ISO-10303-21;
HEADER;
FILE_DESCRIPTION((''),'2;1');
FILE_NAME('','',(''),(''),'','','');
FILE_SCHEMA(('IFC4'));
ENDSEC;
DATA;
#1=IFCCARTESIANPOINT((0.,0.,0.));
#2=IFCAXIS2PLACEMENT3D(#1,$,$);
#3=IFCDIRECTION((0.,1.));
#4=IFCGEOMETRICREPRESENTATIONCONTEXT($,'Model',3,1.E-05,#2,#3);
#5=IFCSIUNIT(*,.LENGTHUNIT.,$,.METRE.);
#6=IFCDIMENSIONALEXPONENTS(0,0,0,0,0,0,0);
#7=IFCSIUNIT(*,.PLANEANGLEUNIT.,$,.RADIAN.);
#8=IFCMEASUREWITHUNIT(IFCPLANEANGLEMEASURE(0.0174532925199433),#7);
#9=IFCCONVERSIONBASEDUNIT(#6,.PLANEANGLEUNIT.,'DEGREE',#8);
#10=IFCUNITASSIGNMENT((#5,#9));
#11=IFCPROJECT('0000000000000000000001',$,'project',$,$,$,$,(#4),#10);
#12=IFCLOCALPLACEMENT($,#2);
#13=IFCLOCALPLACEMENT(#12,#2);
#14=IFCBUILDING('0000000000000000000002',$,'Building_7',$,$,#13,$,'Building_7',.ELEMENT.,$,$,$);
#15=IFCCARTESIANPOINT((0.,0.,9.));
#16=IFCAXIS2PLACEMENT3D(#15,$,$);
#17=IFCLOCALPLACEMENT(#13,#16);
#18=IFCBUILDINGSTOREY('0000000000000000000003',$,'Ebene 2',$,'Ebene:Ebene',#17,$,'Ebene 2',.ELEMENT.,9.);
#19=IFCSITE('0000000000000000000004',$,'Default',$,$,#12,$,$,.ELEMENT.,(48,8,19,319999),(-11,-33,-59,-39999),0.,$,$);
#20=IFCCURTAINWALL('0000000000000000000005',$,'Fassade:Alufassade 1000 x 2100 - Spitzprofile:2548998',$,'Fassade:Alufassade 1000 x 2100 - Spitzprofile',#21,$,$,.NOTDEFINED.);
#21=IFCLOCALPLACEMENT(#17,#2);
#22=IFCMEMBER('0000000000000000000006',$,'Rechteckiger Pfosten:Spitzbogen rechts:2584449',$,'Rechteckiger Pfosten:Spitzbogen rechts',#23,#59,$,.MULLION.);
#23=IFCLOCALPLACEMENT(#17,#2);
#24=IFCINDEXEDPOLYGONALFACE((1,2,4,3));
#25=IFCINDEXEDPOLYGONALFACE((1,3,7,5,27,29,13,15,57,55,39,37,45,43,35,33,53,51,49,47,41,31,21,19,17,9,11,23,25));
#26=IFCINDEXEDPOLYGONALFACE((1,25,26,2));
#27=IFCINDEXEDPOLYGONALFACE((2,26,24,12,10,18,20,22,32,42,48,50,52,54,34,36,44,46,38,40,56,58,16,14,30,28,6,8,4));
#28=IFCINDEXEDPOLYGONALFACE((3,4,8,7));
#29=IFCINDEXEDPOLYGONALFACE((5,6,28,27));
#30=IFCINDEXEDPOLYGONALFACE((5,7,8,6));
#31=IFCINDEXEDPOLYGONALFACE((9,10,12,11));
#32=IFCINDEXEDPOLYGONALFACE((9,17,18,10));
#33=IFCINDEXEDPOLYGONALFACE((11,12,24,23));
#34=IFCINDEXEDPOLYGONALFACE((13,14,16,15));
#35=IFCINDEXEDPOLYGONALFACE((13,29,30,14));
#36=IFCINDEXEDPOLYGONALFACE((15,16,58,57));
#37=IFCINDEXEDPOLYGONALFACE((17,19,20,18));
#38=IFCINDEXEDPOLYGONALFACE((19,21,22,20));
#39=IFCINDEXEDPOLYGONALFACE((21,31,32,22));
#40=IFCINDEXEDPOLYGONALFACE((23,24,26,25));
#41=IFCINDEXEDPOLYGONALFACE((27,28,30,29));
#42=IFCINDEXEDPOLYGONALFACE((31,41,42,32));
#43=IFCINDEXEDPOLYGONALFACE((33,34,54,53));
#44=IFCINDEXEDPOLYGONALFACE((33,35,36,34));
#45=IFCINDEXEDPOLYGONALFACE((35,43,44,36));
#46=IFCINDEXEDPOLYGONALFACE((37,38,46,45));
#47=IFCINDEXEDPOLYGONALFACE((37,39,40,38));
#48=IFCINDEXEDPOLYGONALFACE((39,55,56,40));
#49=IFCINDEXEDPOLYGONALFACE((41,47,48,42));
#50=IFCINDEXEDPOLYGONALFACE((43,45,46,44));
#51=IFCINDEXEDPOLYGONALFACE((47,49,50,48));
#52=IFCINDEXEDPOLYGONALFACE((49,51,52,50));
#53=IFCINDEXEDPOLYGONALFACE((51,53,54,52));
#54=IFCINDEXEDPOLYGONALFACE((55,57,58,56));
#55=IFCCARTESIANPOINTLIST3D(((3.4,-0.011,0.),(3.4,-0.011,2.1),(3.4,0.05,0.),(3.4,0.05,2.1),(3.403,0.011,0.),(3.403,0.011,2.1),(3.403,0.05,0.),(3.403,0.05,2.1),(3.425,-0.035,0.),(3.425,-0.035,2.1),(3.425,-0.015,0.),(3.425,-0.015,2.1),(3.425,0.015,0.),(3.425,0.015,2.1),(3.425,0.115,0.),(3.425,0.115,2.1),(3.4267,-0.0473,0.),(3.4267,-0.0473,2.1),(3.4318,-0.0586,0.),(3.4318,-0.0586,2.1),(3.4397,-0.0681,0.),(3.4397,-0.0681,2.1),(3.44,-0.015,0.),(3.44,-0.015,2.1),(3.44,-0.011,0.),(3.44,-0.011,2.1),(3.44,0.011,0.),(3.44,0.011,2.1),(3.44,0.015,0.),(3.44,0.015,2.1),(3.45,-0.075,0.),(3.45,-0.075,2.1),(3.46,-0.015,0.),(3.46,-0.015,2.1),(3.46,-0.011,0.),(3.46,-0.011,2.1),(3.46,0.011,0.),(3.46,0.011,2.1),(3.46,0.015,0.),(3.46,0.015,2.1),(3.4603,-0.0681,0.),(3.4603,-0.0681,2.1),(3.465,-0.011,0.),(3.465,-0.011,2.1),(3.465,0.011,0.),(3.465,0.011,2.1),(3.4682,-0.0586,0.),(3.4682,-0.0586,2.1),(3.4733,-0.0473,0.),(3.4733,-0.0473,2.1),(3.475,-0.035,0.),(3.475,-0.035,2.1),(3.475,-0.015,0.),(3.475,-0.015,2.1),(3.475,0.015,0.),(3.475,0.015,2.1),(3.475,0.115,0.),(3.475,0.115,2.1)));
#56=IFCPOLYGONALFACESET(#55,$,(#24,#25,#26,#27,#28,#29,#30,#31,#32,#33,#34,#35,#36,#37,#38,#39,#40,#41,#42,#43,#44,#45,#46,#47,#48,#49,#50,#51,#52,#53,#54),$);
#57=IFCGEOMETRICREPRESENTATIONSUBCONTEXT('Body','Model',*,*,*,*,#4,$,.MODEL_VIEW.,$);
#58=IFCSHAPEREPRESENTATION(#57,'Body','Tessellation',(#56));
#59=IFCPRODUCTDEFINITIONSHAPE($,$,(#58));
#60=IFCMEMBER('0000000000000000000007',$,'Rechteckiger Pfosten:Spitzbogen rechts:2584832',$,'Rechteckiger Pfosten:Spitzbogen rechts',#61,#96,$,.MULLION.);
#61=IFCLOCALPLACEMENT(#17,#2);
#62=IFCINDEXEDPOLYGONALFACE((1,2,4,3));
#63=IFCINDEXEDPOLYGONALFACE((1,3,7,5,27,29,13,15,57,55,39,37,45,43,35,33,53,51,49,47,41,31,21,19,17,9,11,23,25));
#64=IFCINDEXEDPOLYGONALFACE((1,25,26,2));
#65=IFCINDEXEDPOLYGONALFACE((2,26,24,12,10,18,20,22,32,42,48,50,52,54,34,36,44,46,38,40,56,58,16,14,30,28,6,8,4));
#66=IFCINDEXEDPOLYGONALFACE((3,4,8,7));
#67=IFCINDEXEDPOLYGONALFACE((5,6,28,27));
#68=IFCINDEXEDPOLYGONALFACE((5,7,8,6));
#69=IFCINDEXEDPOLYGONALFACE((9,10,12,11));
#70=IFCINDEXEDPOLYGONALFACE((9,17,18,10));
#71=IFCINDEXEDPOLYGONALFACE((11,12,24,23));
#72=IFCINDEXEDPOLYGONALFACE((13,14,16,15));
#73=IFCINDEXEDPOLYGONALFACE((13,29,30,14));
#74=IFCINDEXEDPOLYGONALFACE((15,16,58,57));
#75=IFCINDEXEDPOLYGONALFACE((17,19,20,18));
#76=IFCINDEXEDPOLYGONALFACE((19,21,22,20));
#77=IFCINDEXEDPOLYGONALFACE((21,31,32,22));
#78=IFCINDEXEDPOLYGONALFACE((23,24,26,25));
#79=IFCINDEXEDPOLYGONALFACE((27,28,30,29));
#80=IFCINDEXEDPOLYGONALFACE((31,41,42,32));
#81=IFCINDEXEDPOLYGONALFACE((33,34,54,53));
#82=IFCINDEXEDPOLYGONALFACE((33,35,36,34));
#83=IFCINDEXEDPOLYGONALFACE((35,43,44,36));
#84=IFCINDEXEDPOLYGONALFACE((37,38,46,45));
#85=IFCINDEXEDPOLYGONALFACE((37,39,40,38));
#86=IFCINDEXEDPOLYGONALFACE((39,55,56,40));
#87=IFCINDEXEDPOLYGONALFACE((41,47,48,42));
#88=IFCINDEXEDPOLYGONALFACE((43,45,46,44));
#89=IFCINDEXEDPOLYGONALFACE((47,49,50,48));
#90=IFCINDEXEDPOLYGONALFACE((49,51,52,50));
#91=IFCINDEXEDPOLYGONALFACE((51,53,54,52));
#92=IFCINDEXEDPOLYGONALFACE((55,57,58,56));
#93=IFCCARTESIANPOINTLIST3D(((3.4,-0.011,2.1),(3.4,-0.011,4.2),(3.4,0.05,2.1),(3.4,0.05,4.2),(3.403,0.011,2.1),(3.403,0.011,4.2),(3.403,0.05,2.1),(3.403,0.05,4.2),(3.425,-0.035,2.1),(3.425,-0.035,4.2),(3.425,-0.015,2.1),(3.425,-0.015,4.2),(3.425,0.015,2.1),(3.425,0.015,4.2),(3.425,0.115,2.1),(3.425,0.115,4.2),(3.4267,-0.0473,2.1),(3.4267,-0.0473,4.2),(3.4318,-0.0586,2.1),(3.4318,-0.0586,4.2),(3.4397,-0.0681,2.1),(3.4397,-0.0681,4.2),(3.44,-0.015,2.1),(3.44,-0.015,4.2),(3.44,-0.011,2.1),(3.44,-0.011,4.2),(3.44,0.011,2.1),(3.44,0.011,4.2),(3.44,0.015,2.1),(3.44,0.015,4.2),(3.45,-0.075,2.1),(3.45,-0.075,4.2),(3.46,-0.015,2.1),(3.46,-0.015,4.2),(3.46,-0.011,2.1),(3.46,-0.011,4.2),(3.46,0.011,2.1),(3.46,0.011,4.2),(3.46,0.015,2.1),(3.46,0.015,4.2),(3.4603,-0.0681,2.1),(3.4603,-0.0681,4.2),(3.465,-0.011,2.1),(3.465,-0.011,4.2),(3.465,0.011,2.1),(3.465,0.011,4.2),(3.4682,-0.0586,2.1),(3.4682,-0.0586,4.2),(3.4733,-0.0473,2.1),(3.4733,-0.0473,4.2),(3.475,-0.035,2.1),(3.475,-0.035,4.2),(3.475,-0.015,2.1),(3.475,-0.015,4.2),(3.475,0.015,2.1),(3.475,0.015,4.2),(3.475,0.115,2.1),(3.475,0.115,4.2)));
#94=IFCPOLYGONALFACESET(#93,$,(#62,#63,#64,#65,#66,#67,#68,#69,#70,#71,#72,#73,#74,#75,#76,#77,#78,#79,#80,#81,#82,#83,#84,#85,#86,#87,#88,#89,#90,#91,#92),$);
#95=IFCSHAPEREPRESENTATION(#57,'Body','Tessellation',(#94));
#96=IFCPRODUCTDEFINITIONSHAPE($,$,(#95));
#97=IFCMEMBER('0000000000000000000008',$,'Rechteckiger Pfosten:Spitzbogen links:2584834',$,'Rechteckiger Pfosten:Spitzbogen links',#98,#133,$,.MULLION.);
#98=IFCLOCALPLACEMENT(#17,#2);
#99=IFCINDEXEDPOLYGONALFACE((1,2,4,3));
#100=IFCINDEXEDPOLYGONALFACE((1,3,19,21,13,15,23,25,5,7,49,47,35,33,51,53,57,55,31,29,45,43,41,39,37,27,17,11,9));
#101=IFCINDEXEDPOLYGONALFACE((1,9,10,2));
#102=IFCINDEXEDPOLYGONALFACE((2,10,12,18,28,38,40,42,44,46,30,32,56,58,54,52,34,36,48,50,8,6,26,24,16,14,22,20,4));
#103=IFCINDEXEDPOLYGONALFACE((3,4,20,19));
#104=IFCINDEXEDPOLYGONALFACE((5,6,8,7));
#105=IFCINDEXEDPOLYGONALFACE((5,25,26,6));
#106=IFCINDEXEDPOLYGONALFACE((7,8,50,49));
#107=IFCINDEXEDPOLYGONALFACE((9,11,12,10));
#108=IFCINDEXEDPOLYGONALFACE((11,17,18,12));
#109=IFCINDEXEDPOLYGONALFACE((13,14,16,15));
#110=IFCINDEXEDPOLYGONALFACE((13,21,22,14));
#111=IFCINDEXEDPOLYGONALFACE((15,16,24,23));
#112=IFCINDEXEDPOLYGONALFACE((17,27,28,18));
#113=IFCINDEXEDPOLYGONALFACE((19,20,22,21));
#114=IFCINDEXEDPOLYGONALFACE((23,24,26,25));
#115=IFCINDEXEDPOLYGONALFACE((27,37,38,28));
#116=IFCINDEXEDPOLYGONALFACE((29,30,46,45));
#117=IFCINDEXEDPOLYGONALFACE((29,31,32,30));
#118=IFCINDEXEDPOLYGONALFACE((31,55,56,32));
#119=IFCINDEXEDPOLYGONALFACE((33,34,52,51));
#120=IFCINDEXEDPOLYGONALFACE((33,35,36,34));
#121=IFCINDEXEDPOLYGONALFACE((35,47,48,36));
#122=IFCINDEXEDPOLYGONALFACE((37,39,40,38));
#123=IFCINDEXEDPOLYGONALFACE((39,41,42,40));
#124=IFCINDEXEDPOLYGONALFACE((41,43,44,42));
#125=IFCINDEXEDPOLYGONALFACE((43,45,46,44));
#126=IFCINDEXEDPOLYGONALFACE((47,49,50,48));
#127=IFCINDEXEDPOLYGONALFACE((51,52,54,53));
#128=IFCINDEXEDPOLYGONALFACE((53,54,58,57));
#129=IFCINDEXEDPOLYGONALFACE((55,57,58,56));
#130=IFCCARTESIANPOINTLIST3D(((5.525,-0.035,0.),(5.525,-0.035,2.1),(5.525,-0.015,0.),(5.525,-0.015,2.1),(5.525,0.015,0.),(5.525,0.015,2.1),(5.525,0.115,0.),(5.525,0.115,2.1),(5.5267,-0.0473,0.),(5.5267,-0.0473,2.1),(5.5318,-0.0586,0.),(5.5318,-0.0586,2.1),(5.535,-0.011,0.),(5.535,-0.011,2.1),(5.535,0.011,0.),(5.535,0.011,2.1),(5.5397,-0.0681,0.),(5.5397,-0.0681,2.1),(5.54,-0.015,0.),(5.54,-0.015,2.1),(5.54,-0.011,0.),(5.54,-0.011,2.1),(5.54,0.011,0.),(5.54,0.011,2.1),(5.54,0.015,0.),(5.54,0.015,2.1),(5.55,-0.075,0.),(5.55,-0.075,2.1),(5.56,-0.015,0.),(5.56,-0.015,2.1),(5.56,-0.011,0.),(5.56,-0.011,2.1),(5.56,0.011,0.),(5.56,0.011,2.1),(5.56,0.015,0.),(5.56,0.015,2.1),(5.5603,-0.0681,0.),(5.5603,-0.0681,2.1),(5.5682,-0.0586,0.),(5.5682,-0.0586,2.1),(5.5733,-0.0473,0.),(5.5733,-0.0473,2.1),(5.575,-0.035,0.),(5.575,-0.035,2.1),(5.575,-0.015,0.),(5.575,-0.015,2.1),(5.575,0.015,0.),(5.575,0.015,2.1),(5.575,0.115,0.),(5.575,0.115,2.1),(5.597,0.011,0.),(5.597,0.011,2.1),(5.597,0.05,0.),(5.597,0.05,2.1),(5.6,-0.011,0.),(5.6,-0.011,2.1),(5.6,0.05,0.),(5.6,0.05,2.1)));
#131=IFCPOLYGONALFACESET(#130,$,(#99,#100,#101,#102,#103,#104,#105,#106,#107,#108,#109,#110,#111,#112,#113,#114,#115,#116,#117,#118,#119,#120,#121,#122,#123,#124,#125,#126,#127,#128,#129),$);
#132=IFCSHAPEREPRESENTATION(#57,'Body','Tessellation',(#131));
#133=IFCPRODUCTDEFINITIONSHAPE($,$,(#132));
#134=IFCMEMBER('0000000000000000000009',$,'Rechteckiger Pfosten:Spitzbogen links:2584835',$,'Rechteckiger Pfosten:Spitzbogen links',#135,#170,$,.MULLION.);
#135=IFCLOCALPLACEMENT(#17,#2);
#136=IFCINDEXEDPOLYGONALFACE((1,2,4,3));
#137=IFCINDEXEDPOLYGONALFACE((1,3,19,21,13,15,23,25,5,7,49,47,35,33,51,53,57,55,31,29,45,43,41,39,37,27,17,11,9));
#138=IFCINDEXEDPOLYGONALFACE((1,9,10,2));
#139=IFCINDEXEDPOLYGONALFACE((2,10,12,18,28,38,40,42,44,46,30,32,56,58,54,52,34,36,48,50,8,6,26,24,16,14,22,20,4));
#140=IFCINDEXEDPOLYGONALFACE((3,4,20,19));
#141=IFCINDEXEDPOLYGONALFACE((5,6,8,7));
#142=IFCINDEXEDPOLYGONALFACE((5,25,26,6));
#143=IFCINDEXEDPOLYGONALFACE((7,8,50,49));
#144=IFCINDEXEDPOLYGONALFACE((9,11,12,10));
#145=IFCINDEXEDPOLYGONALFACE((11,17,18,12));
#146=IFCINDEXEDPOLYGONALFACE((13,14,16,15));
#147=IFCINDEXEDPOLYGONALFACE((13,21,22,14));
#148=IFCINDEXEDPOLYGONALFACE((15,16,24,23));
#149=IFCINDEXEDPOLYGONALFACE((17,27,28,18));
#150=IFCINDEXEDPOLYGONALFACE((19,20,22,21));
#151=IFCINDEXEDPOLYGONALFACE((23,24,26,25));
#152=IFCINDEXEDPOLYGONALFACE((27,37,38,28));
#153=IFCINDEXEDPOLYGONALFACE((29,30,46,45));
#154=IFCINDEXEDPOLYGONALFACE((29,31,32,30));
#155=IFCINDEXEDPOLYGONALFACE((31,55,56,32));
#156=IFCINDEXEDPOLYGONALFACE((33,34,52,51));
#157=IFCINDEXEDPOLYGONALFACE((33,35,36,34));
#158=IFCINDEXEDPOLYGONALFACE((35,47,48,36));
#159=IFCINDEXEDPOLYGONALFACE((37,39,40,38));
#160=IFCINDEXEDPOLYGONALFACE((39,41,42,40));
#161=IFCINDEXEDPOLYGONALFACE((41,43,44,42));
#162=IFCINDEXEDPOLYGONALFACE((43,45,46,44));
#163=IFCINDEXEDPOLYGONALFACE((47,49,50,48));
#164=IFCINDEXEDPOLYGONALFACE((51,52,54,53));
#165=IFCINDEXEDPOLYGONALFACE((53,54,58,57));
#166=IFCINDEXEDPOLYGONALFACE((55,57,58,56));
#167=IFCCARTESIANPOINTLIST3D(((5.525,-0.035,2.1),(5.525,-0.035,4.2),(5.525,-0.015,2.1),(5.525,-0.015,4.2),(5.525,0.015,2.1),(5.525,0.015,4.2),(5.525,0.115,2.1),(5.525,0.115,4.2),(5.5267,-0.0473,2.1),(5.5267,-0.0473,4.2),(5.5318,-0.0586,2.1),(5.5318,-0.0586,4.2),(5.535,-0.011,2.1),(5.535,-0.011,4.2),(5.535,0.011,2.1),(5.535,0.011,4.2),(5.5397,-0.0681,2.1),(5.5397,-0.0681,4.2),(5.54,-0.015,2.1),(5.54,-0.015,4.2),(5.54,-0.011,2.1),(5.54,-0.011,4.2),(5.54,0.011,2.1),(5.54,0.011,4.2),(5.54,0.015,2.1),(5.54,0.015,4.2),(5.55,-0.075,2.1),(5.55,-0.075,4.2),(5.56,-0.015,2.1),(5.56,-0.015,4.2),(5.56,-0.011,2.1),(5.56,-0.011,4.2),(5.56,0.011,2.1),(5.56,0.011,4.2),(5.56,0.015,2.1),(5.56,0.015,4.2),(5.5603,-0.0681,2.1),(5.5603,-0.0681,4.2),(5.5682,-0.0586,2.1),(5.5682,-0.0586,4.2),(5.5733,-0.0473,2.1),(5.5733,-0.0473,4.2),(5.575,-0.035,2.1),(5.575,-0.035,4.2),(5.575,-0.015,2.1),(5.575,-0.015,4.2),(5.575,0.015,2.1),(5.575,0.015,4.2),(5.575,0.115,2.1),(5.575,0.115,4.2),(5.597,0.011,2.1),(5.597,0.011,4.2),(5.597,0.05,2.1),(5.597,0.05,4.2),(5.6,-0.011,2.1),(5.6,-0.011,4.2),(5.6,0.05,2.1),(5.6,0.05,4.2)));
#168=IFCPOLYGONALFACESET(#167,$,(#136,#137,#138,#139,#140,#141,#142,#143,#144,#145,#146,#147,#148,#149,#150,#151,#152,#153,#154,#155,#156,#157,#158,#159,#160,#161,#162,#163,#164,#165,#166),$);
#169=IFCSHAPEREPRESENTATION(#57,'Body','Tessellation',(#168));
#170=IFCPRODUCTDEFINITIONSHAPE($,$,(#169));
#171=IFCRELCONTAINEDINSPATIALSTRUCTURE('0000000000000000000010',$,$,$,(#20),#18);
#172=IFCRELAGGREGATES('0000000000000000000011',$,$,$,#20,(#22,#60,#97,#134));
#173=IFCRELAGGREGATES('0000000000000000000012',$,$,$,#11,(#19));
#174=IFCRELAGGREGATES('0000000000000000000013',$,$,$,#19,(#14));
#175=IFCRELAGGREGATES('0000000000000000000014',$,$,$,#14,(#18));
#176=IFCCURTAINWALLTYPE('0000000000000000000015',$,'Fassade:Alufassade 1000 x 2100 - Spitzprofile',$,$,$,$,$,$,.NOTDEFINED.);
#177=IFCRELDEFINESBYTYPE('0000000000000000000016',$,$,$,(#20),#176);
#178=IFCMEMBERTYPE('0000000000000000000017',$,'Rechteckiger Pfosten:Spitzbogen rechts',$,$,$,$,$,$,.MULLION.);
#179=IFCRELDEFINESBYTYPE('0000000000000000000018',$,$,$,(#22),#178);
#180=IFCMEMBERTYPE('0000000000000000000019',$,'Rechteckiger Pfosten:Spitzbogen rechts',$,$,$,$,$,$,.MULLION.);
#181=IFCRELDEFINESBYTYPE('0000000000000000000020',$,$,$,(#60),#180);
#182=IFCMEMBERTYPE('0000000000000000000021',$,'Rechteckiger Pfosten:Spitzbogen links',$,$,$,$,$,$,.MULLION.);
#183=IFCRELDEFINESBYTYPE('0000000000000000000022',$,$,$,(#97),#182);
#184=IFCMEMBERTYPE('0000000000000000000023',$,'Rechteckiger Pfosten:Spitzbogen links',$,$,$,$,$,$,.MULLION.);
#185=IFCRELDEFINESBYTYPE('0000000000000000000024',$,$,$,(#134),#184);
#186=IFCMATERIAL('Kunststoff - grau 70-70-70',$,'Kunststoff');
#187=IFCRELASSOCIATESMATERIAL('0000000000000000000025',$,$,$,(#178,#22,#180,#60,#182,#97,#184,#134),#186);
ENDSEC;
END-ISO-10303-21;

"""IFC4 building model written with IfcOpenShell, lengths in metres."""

from ifc_helpers import new_model, entity, si_unit, converted_unit, direction, frame, origin, place, context, subcontext, project, spatial, line, arc, indexed_curve, outline, extrude, source, transform, mapped, material, type_object, type_shapes, element, aggregate, save


model = new_model("IFC4")

# Units and contexts
model_context = context("Model", 3, precision=1e-05, world=origin(), true_north=direction((0.0, 1.0)))
body_context = subcontext(model_context, "Body", "Model", "MODEL_VIEW")
ifc_project = project(units=[si_unit("LENGTHUNIT", "METRE"), converted_unit("PLANEANGLEUNIT", "DEGREE", entity("IfcPlaneAngleMeasure", 0.0174532925199433), si_unit("PLANEANGLEUNIT", "RADIAN"), dimensions=[0, 0, 0, 0, 0, 0, 0])], contexts=[model_context])

# Site, building, storey
site_placement = place(None, origin())
site = spatial("IfcSite", under=ifc_project, at=site_placement, Name="Default", CompositionType="ELEMENT", RefLatitude=(48, 8, 19, 319999), RefLongitude=(-11, -33, -59, -39999), RefElevation=0.0)
building_placement = place(site_placement, origin())
building = spatial("IfcBuilding", under=site, at=building_placement, Name="Building_7", LongName="Building_7", CompositionType="ELEMENT")
storey_placement = place(building_placement, frame((0.0, 0.0, 9.0)))
storey = spatial("IfcBuildingStorey", under=building, at=storey_placement, Name="Ebene 2", ObjectType="Ebene:Ebene", LongName="Ebene 2", CompositionType="ELEMENT", Elevation=9.0)

# Curtain wall, members
curtain_wall_type = type_object("IfcCurtainWallType", Name="Fassade:Alufassade 1000 x 2100 - Spitzprofile", PredefinedType="NOTDEFINED")
curtain_wall_placement = place(storey_placement, frame((0.0, 0.0, -9.0)))
curtain_wall = element("IfcCurtainWall", 1, at=curtain_wall_placement, inside=storey, type_object=curtain_wall_type, Name="Fassade:Alufassade 1000 x 2100 - Spitzprofile:2548998", ObjectType="Fassade:Alufassade 1000 x 2100 - Spitzprofile", PredefinedType="NOTDEFINED")
ifc_material_1 = material(Name="Kunststoff - grau 70-70-70", Category="Kunststoff")
member_type_1 = type_object("IfcMemberType", Name="Rechteckiger Pfosten:Spitzbogen rechts", PredefinedType="MULLION", material=ifc_material_1)
shared_shape_1 = source(origin(), body_context, "Body", "SweptSolid", [
    extrude(outline(indexed_curve([(-0.107, -0.0321), (-0.007, -0.0321), (-0.007, -0.0171), (-0.003, -0.0171), (-0.003, -0.0221), (0.019, -0.0221), (0.019, -0.0171), (0.023, -0.0171), (0.023, -0.0321), (0.043, -0.0321), (0.0666, -0.0254), (0.083, -0.0071), (0.0666, 0.0111), (0.043, 0.0179), (0.023, 0.0179), (0.023, 0.0029), (0.019, 0.0029), (0.019, 0.0429), (-0.042, 0.0429), (-0.042, 0.0399), (-0.003, 0.0399), (-0.003, 0.0029), (-0.007, 0.0029), (-0.007, 0.0179), (-0.107, 0.0179)], segments=[line(1, 2, 3, 4, 5, 6, 7, 8, 9, 10), arc(10, 11, 12), arc(12, 13, 14), line(14, 15, 16, 17, 18, 19, 20, 21, 22, 23, 24, 25, 1)], self_intersect=False)), frame((-0.0429, 0.008, -2.1), z_axis=(0.0, 0.0, 1.0), x_axis=(0.0, -1.0, 0.0)), (0.0, 0.0, 1.0), 2.1),
])
type_shapes(member_type_1, [shared_shape_1])
member_1_placement = place(curtain_wall_placement, frame((3.4, 0.0, 9.0), z_axis=(0.0, 0.0, -1.0), x_axis=(-1.0, 0.0, 0.0)))
member_1 = element("IfcMember", 2, at=member_1_placement, type_object=member_type_1, material=ifc_material_1, Name="Rechteckiger Pfosten:Spitzbogen rechts:2584449", ObjectType="Rechteckiger Pfosten:Spitzbogen rechts", PredefinedType="MULLION", context=body_context, shape_type="MappedRepresentation", body=[
    mapped(shared_shape_1, transform((0.0, 0.0, 0.0), scale=1.0)),
])
member_type_2 = type_object("IfcMemberType", Name="Rechteckiger Pfosten:Spitzbogen rechts", PredefinedType="MULLION", material=ifc_material_1)
shared_shape_2 = source(origin(), body_context, "Body", "SweptSolid", [
    extrude(outline(indexed_curve([(-0.107, -0.0321), (-0.007, -0.0321), (-0.007, -0.0171), (-0.003, -0.0171), (-0.003, -0.0221), (0.019, -0.0221), (0.019, -0.0171), (0.023, -0.0171), (0.023, -0.0321), (0.043, -0.0321), (0.0666, -0.0254), (0.083, -0.0071), (0.0666, 0.0111), (0.043, 0.0179), (0.023, 0.0179), (0.023, 0.0029), (0.019, 0.0029), (0.019, 0.0429), (-0.042, 0.0429), (-0.042, 0.0399), (-0.003, 0.0399), (-0.003, 0.0029), (-0.007, 0.0029), (-0.007, 0.0179), (-0.107, 0.0179)], segments=[line(1, 2, 3, 4, 5, 6, 7, 8, 9, 10), arc(10, 11, 12), arc(12, 13, 14), line(14, 15, 16, 17, 18, 19, 20, 21, 22, 23, 24, 25, 1)], self_intersect=False)), frame((-0.0429, 0.008, -2.1), z_axis=(0.0, 0.0, 1.0), x_axis=(0.0, -1.0, 0.0)), (0.0, 0.0, 1.0), 2.1),
])
type_shapes(member_type_2, [shared_shape_2])
member_2_placement = place(curtain_wall_placement, frame((3.4, 0.0, 11.1), z_axis=(0.0, 0.0, -1.0), x_axis=(-1.0, 0.0, 0.0)))
member_2 = element("IfcMember", 3, at=member_2_placement, type_object=member_type_2, material=ifc_material_1, Name="Rechteckiger Pfosten:Spitzbogen rechts:2584832", ObjectType="Rechteckiger Pfosten:Spitzbogen rechts", PredefinedType="MULLION", context=body_context, shape_type="MappedRepresentation", body=[
    mapped(shared_shape_2, transform((0.0, 0.0, 0.0), scale=1.0)),
])
member_type_3 = type_object("IfcMemberType", Name="Rechteckiger Pfosten:Spitzbogen links", PredefinedType="MULLION", material=ifc_material_1)
shared_shape_3 = source(origin(), body_context, "Body", "SweptSolid", [
    extrude(outline(indexed_curve([(-0.107, -0.0321), (-0.007, -0.0321), (-0.007, -0.0171), (-0.003, -0.0171), (-0.003, -0.0221), (0.019, -0.0221), (0.019, -0.0171), (0.023, -0.0171), (0.023, -0.0321), (0.043, -0.0321), (0.0666, -0.0254), (0.083, -0.0071), (0.0666, 0.0111), (0.043, 0.0179), (0.023, 0.0179), (0.023, 0.0029), (0.019, 0.0029), (0.019, 0.0429), (-0.042, 0.0429), (-0.042, 0.0399), (-0.003, 0.0399), (-0.003, 0.0029), (-0.007, 0.0029), (-0.007, 0.0179), (-0.107, 0.0179)], segments=[line(1, 2, 3, 4, 5, 6, 7, 8, 9, 10), arc(10, 11, 12), arc(12, 13, 14), line(14, 15, 16, 17, 18, 19, 20, 21, 22, 23, 24, 25, 1)], self_intersect=False)), frame((-0.0429, 0.008, -2.1), z_axis=(0.0, 0.0, 1.0), x_axis=(0.0, -1.0, 0.0)), (0.0, 0.0, 1.0), 2.1),
])
type_shapes(member_type_3, [shared_shape_3])
member_3_placement = place(curtain_wall_placement, frame((5.6, 0.0, 11.1)))
member_3 = element("IfcMember", 4, at=member_3_placement, type_object=member_type_3, material=ifc_material_1, Name="Rechteckiger Pfosten:Spitzbogen links:2584834", ObjectType="Rechteckiger Pfosten:Spitzbogen links", PredefinedType="MULLION", context=body_context, shape_type="MappedRepresentation", body=[
    mapped(shared_shape_3, transform((0.0, 0.0, 0.0), scale=1.0)),
])
member_type_4 = type_object("IfcMemberType", Name="Rechteckiger Pfosten:Spitzbogen links", PredefinedType="MULLION", material=ifc_material_1)
shared_shape_4 = source(origin(), body_context, "Body", "SweptSolid", [
    extrude(outline(indexed_curve([(-0.107, -0.0321), (-0.007, -0.0321), (-0.007, -0.0171), (-0.003, -0.0171), (-0.003, -0.0221), (0.019, -0.0221), (0.019, -0.0171), (0.023, -0.0171), (0.023, -0.0321), (0.043, -0.0321), (0.0666, -0.0254), (0.083, -0.0071), (0.0666, 0.0111), (0.043, 0.0179), (0.023, 0.0179), (0.023, 0.0029), (0.019, 0.0029), (0.019, 0.0429), (-0.042, 0.0429), (-0.042, 0.0399), (-0.003, 0.0399), (-0.003, 0.0029), (-0.007, 0.0029), (-0.007, 0.0179), (-0.107, 0.0179)], segments=[line(1, 2, 3, 4, 5, 6, 7, 8, 9, 10), arc(10, 11, 12), arc(12, 13, 14), line(14, 15, 16, 17, 18, 19, 20, 21, 22, 23, 24, 25, 1)], self_intersect=False)), frame((-0.0429, 0.008, -2.1), z_axis=(0.0, 0.0, 1.0), x_axis=(0.0, -1.0, 0.0)), (0.0, 0.0, 1.0), 2.1),
])
type_shapes(member_type_4, [shared_shape_4])
member_4_placement = place(curtain_wall_placement, frame((5.6, 0.0, 13.2)))
member_4 = element("IfcMember", 5, at=member_4_placement, type_object=member_type_4, material=ifc_material_1, Name="Rechteckiger Pfosten:Spitzbogen links:2584835", ObjectType="Rechteckiger Pfosten:Spitzbogen links", PredefinedType="MULLION", context=body_context, shape_type="MappedRepresentation", body=[
    mapped(shared_shape_4, transform((0.0, 0.0, 0.0), scale=1.0)),
])

aggregate(curtain_wall, [member_1, member_2, member_3, member_4])

save(model, "model.ifc")
